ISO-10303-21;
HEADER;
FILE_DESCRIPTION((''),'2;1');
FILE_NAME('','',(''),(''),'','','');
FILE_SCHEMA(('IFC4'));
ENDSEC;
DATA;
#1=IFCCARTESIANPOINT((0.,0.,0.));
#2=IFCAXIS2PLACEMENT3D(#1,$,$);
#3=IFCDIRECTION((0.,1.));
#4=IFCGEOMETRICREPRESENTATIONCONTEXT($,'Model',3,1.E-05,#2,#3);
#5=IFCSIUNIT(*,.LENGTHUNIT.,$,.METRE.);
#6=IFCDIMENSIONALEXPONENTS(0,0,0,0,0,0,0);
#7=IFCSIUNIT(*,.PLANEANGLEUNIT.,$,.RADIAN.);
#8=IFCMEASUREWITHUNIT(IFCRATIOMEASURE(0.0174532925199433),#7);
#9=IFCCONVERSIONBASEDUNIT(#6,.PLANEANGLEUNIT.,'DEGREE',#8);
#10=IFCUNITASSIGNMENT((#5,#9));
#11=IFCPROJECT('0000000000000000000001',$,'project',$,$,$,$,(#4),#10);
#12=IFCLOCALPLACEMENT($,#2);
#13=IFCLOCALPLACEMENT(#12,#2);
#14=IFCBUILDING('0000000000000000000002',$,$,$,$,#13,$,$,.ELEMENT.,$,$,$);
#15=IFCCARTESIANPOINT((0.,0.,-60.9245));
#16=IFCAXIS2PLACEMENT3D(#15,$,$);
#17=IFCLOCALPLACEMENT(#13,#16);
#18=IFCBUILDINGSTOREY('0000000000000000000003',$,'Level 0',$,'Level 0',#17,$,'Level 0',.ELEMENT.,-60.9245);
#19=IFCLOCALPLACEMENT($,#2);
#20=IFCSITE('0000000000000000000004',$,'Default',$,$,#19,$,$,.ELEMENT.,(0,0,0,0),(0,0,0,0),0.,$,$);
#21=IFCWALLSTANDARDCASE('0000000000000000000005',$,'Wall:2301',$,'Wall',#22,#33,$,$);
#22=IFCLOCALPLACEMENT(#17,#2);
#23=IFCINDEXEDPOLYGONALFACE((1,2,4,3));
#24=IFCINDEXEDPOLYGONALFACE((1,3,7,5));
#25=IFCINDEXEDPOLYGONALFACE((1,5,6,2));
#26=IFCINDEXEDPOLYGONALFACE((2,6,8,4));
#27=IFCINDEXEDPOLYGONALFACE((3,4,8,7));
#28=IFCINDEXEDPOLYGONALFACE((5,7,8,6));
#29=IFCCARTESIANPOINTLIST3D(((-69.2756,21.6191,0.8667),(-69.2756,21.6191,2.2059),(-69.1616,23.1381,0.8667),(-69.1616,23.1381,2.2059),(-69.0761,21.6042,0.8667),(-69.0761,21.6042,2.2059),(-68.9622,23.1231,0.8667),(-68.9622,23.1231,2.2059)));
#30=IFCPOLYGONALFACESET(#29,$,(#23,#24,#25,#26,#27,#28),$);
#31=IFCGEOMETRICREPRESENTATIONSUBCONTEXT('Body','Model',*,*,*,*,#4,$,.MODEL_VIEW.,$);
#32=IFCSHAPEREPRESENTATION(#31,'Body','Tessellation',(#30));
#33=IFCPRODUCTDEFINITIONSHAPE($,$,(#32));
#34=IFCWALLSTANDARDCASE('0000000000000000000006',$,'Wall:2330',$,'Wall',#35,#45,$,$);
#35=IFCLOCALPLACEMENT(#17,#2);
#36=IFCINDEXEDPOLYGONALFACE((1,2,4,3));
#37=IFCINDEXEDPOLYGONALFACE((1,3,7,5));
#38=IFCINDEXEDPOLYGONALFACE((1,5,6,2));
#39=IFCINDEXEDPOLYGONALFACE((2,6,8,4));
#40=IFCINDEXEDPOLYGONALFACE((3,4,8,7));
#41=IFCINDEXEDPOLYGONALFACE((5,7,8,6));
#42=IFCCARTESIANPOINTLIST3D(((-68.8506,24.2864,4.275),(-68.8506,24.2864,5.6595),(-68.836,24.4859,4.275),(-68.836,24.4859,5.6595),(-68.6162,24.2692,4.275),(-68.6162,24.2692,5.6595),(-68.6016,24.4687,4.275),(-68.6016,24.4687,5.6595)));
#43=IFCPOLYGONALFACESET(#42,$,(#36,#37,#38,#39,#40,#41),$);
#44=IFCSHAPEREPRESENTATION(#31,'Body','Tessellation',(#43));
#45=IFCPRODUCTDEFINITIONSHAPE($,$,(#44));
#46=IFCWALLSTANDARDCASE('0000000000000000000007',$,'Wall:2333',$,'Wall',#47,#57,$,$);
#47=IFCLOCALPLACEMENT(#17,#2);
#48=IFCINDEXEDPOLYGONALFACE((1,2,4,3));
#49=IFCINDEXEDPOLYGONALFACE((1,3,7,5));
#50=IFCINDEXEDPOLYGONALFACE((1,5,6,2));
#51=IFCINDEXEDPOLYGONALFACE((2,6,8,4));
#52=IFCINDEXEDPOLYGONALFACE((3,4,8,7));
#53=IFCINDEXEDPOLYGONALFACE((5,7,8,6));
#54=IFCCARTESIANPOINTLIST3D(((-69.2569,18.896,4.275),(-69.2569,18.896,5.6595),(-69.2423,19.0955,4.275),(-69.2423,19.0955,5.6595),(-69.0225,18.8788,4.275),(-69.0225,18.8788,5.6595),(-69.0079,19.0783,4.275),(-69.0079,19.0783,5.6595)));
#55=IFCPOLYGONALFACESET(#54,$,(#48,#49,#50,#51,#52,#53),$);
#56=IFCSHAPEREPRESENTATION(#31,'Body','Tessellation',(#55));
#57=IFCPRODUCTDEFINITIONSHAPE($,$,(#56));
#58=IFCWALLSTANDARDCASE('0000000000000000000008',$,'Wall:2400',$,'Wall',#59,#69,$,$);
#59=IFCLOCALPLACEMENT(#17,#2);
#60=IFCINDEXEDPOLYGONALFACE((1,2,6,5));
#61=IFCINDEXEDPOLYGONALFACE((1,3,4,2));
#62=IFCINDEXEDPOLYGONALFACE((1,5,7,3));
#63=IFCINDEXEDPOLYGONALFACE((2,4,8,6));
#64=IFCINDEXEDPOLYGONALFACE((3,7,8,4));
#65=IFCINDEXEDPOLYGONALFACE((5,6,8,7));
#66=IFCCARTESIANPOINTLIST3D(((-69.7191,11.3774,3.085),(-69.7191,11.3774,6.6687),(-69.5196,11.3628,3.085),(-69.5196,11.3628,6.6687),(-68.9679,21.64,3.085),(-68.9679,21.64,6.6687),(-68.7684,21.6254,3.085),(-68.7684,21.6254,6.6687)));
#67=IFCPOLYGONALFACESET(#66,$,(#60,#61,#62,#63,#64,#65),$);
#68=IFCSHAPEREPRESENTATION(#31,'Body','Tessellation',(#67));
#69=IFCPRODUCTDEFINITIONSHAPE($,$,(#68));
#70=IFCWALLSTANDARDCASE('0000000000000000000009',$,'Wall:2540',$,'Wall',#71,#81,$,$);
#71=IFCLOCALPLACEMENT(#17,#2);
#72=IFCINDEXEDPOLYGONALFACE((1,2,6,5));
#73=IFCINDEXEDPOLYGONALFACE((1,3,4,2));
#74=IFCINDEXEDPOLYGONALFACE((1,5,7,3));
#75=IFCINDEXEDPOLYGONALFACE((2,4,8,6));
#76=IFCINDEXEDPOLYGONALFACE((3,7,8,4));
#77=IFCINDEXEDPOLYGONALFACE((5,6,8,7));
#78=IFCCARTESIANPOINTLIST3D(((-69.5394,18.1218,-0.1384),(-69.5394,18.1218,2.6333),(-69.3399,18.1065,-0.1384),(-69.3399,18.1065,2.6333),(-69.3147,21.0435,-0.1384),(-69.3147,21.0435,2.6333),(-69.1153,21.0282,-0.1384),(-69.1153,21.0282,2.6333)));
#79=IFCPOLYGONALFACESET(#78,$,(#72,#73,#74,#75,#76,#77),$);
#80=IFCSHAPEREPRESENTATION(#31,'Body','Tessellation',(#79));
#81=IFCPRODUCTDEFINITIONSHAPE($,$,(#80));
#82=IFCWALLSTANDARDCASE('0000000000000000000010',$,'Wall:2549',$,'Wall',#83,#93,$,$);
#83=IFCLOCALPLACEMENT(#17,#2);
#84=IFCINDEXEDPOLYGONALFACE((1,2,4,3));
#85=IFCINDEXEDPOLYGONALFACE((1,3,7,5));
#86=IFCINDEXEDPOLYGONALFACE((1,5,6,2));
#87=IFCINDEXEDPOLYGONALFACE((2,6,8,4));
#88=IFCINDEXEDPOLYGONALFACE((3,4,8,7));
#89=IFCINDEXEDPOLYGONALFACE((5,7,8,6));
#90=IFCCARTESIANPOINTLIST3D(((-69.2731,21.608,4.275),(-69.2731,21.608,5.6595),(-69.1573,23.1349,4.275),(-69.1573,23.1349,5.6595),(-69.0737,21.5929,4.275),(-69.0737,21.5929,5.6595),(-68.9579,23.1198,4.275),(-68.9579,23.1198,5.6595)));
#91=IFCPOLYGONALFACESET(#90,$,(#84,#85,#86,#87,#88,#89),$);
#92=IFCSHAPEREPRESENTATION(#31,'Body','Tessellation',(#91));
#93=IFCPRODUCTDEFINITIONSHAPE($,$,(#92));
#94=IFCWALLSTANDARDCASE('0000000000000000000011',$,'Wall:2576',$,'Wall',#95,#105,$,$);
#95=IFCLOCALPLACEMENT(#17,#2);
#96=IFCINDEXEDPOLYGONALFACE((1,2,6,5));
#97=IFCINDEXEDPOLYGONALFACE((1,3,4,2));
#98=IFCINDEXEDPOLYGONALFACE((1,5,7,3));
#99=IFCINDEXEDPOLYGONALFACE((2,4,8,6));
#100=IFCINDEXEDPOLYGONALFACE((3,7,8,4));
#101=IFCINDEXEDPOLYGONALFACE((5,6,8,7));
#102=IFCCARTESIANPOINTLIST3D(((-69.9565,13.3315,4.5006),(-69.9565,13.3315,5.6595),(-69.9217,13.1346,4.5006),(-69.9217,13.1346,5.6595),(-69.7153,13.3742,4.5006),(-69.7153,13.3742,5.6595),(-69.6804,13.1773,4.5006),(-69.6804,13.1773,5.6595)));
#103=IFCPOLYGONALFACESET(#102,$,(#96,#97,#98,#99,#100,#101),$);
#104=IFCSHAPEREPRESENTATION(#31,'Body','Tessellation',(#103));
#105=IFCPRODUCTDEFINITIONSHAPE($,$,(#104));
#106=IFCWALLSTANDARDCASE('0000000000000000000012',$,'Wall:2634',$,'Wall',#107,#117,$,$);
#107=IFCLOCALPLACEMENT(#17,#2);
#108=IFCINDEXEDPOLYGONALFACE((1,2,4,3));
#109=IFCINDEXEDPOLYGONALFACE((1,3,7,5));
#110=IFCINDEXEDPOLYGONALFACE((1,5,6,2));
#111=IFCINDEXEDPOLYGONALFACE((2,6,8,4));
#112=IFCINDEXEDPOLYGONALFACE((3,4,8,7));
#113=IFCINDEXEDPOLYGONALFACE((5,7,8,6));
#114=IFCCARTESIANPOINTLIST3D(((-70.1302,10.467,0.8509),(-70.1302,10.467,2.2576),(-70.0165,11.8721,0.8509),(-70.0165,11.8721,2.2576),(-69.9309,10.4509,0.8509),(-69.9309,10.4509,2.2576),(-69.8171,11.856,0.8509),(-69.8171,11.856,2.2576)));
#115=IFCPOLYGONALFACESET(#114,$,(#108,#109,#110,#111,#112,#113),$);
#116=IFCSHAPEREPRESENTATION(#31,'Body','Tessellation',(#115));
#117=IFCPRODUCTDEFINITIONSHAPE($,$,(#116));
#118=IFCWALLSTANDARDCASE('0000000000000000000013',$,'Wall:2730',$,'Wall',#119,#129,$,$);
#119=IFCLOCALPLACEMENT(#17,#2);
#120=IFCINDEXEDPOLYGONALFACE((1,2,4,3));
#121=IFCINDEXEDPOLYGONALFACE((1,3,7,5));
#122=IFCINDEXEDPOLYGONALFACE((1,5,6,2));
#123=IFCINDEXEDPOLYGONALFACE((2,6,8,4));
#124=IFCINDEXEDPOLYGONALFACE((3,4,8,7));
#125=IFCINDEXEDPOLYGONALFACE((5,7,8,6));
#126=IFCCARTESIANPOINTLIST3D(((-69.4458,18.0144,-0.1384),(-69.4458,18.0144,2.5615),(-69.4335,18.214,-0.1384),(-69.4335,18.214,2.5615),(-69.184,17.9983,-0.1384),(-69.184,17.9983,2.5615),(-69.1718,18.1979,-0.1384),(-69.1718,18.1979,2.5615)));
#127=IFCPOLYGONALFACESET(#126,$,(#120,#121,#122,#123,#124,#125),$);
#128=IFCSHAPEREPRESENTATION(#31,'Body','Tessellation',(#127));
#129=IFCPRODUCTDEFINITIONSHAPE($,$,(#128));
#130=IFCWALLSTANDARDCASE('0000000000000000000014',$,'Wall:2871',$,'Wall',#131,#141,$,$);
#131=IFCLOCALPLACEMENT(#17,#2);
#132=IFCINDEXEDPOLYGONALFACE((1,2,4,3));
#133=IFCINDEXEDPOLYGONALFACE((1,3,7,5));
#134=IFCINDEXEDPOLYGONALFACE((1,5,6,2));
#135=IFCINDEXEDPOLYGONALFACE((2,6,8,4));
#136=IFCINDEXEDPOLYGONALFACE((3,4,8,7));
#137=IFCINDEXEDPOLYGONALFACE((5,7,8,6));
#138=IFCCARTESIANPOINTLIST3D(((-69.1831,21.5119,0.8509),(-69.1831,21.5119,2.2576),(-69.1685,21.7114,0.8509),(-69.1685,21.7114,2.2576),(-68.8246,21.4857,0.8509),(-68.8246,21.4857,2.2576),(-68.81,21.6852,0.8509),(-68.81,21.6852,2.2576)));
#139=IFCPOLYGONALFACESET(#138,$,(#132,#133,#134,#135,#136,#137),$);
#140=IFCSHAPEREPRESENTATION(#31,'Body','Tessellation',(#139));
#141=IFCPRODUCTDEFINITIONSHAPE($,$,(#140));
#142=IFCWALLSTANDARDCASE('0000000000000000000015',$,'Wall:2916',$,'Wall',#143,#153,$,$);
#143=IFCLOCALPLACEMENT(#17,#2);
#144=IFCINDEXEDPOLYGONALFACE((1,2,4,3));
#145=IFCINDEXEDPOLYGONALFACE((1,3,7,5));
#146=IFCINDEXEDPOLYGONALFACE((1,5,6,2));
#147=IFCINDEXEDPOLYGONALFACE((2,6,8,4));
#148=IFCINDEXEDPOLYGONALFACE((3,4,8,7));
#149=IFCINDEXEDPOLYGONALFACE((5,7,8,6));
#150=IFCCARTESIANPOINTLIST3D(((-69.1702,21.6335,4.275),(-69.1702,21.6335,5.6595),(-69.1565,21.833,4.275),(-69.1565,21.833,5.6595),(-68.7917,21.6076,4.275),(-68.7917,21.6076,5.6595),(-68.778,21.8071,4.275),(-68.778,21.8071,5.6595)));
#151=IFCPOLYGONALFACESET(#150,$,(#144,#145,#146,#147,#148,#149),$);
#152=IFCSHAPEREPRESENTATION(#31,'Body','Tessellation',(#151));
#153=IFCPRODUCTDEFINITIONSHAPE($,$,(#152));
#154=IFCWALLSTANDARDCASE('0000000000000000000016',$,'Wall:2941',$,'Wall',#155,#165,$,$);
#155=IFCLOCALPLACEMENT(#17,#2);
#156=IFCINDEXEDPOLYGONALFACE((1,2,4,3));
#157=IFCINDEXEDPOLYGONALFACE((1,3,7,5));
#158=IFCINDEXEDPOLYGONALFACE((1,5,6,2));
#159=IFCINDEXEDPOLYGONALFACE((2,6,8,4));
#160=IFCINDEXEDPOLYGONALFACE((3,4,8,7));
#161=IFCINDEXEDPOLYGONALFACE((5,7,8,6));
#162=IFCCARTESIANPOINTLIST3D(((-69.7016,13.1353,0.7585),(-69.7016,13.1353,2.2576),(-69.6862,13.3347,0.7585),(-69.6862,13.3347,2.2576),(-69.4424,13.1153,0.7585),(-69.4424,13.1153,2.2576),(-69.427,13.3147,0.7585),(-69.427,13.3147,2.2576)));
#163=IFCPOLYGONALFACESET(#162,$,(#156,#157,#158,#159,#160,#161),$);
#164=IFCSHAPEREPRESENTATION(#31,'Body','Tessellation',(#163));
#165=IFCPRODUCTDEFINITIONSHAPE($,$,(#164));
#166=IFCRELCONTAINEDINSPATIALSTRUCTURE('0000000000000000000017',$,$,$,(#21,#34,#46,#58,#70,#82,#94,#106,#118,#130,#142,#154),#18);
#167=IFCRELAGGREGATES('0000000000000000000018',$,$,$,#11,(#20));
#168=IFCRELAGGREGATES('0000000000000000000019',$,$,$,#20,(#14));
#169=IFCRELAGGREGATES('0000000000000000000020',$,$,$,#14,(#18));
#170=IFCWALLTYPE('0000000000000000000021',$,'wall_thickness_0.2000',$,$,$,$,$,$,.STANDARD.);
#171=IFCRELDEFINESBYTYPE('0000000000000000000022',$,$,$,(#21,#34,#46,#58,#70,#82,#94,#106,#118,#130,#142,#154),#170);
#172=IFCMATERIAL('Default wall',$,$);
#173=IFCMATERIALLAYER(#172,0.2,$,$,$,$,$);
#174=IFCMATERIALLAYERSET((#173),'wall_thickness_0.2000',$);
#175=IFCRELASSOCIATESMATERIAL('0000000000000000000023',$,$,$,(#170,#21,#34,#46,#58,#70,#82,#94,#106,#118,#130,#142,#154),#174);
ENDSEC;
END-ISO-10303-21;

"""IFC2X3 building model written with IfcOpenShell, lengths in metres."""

from ifc_helpers import new_model, entity, si_unit, converted_unit, direction, frame, origin, place, context, subcontext, project, spatial, polyline, outline, extrude, material, layer, layer_set, layer_usage, type_object, element, save


model = new_model("IFC2X3")

# Units and contexts
model_context = context("Model", 3, precision=1e-05, world=origin(), true_north=direction((0.0, 1.0)))
body_context = subcontext(model_context, "Body", "Model", "MODEL_VIEW")
ifc_project = project(units=[si_unit("LENGTHUNIT", "METRE"), converted_unit("PLANEANGLEUNIT", "DEGREE", entity("IfcRatioMeasure", 0.0174532925199433), si_unit("PLANEANGLEUNIT", "RADIAN"), dimensions=[0, 0, 0, 0, 0, 0, 0])], contexts=[model_context])

# Site, building, storey
site_placement = place(None, origin())
site = spatial("IfcSite", under=ifc_project, at=site_placement, Name="Default", CompositionType="ELEMENT", RefLatitude=(0, 0, 0, 0), RefLongitude=(0, 0, 0, 0), RefElevation=0.0)
placement_1 = place(None, origin())
building_placement = place(placement_1, origin())
building = spatial("IfcBuilding", under=site, at=building_placement, CompositionType="ELEMENT")
storey_placement = place(building_placement, frame((0.0, 0.0, -60.9245)))
storey = spatial("IfcBuildingStorey", under=building, at=storey_placement, Name="Level 0", ObjectType="Level 0", LongName="Level 0", CompositionType="ELEMENT", Elevation=-60.9245)

# Walls
ifc_material = material(Name="Default wall")
ifc_layer = layer(ifc_material, 0.2)
ifc_layer_set = layer_set([ifc_layer], Name="wall_thickness_0.2000")
ifc_layer_usage = layer_usage(ifc_layer_set, "AXIS2", "POSITIVE", -0.1)
wall_type = type_object("IfcWallType", Name="wall_thickness_0.2000", PredefinedType="STANDARD", material=ifc_layer_set)
placement_2 = place(building_placement, frame((0.0, 0.0, -60.0578)))
wall_1_placement = place(placement_2, frame((-69.0619, 23.1306, 0.0), z_axis=(0.0, 0.0, 1.0), x_axis=(-0.074784, -0.9972, 0.0)))
element("IfcWallStandardCase", 1, at=wall_1_placement, inside=storey, type_object=wall_type, material=ifc_layer_usage, Name="Wall:2301", ObjectType="Wall", context=body_context, shape_type="SweptSolid", body=[
    extrude(outline(polyline([(1.5232, -0.1), (1.5232, 0.1), (0.0, 0.1), (0.0, -0.1), (1.5232, -0.1)])), origin(), (0.0, 0.0, 1.0), 1.3392),
])
placement_3 = place(building_placement, frame((0.0, 0.0, -56.6495)))
wall_2_placement = place(placement_3, frame((-68.6089, 24.369, 0.0), z_axis=(0.0, 0.0, 1.0), x_axis=(-0.997327, 0.073063, 0.0)))
element("IfcWallStandardCase", 2, at=wall_2_placement, inside=storey, type_object=wall_type, material=ifc_layer_usage, Name="Wall:2330", ObjectType="Wall", context=body_context, shape_type="SweptSolid", body=[
    extrude(outline(polyline([(0.235, -0.1), (0.235, 0.1), (0.0, 0.1), (0.0, -0.1), (0.235, -0.1)])), origin(), (0.0, 0.0, 1.0), 1.3845),
])
placement_4 = place(building_placement, frame((0.0, 0.0, -56.6495)))
wall_3_placement = place(placement_4, frame((-69.0152, 18.9786, 0.0), z_axis=(0.0, 0.0, 1.0), x_axis=(-0.997326, 0.073081, 0.0)))
element("IfcWallStandardCase", 3, at=wall_3_placement, inside=storey, type_object=wall_type, material=ifc_layer_usage, Name="Wall:2333", ObjectType="Wall", context=body_context, shape_type="SweptSolid", body=[
    extrude(outline(polyline([(0.235, -0.1), (0.235, 0.1), (0.0, 0.1), (0.0, -0.1), (0.235, -0.1)])), origin(), (0.0, 0.0, 1.0), 1.3845),
])
placement_5 = place(building_placement, frame((0.0, 0.0, -57.8395)))
wall_4_placement = place(placement_5, frame((-68.8681, 21.6327, 0.0), z_axis=(0.0, 0.0, 1.0), x_axis=(-0.073003, -0.997332, 0.0)))
element("IfcWallStandardCase", 4, at=wall_4_placement, inside=storey, type_object=wall_type, material=ifc_layer_usage, Name="Wall:2400", ObjectType="Wall", context=body_context, shape_type="SweptSolid", body=[
    extrude(outline(polyline([(10.29, -0.1), (10.29, 0.1), (0.0, 0.1), (0.0, -0.1), (10.29, -0.1)])), origin(), (0.0, 0.0, 1.0), 3.5837),
])
placement_6 = place(building_placement, frame((0.0, 0.0, -61.0629)))
wall_5_placement = place(placement_6, frame((-69.215, 21.0358, 0.0), z_axis=(0.0, 0.0, 1.0), x_axis=(-0.076651, -0.997058, 0.0)))
element("IfcWallStandardCase", 5, at=wall_5_placement, inside=storey, type_object=wall_type, material=ifc_layer_usage, Name="Wall:2540", ObjectType="Wall", context=body_context, shape_type="SweptSolid", body=[
    extrude(outline(polyline([(2.9303, -0.1), (2.9303, 0.1), (0.0, 0.1), (0.0, -0.1), (2.9303, -0.1)])), origin(), (0.0, 0.0, 1.0), 2.7716),
])
placement_7 = place(building_placement, frame((0.0, 0.0, -56.6495)))
wall_6_placement = place(placement_7, frame((-69.0576, 23.1274, 0.0), z_axis=(0.0, 0.0, 1.0), x_axis=(-0.075624, -0.997136, 0.0)))
element("IfcWallStandardCase", 6, at=wall_6_placement, inside=storey, type_object=wall_type, material=ifc_layer_usage, Name="Wall:2549", ObjectType="Wall", context=body_context, shape_type="SweptSolid", body=[
    extrude(outline(polyline([(1.5313, -0.1), (1.5313, 0.1), (0.0, 0.1), (0.0, -0.1), (1.5313, -0.1)])), origin(), (0.0, 0.0, 1.0), 1.3845),
])
placement_8 = place(building_placement, frame((0.0, 0.0, -56.4239)))
wall_7_placement = place(placement_8, frame((-69.6979, 13.2758, 0.0), z_axis=(0.0, 0.0, 1.0), x_axis=(-0.984687, -0.174331, 0.0)))
element("IfcWallStandardCase", 7, at=wall_7_placement, inside=storey, type_object=wall_type, material=ifc_layer_usage, Name="Wall:2576", ObjectType="Wall", context=body_context, shape_type="SweptSolid", body=[
    extrude(outline(polyline([(0.245, -0.1), (0.245, 0.1), (0.0, 0.1), (0.0, -0.1), (0.245, -0.1)])), origin(), (0.0, 0.0, 1.0), 1.1589),
])
placement_9 = place(building_placement, frame((0.0, 0.0, -60.0736)))
wall_8_placement = place(placement_9, frame((-69.9168, 11.864, 0.0), z_axis=(0.0, 0.0, 1.0), x_axis=(-0.080694, -0.996739, 0.0)))
element("IfcWallStandardCase", 8, at=wall_8_placement, inside=storey, type_object=wall_type, material=ifc_layer_usage, Name="Wall:2634", ObjectType="Wall", context=body_context, shape_type="SweptSolid", body=[
    extrude(outline(polyline([(1.4097, -0.1), (1.4097, 0.1), (0.0, 0.1), (0.0, -0.1), (1.4097, -0.1)])), origin(), (0.0, 0.0, 1.0), 1.4068),
])
placement_10 = place(building_placement, frame((0.0, 0.0, -61.0629)))
wall_9_placement = place(placement_10, frame((-69.1779, 18.0981, 0.0), z_axis=(0.0, 0.0, 1.0), x_axis=(-0.998125, 0.061214, 0.0)))
element("IfcWallStandardCase", 9, at=wall_9_placement, inside=storey, type_object=wall_type, material=ifc_layer_usage, Name="Wall:2730", ObjectType="Wall", context=body_context, shape_type="SweptSolid", body=[
    extrude(outline(polyline([(0.2623, -0.1), (0.2623, 0.1), (0.0, 0.1), (0.0, -0.1), (0.2623, -0.1)])), origin(), (0.0, 0.0, 1.0), 2.6999),
])
placement_11 = place(building_placement, frame((0.0, 0.0, -60.0736)))
wall_10_placement = place(placement_11, frame((-68.8173, 21.5854, 0.0), z_axis=(0.0, 0.0, 1.0), x_axis=(-0.997342, 0.072862, 0.0)))
element("IfcWallStandardCase", 10, at=wall_10_placement, inside=storey, type_object=wall_type, material=ifc_layer_usage, Name="Wall:2871", ObjectType="Wall", context=body_context, shape_type="SweptSolid", body=[
    extrude(outline(polyline([(0.3595, -0.1), (0.3595, 0.1), (0.0, 0.1), (0.0, -0.1), (0.3595, -0.1)])), origin(), (0.0, 0.0, 1.0), 1.4068),
])
placement_12 = place(building_placement, frame((0.0, 0.0, -56.6495)))
wall_11_placement = place(placement_12, frame((-68.7849, 21.7073, 0.0), z_axis=(0.0, 0.0, 1.0), x_axis=(-0.997661, 0.068361, 0.0)))
element("IfcWallStandardCase", 11, at=wall_11_placement, inside=storey, type_object=wall_type, material=ifc_layer_usage, Name="Wall:2916", ObjectType="Wall", context=body_context, shape_type="SweptSolid", body=[
    extrude(outline(polyline([(0.3793, -0.1), (0.3793, 0.1), (0.0, 0.1), (0.0, -0.1), (0.3793, -0.1)])), origin(), (0.0, 0.0, 1.0), 1.3845),
])
placement_13 = place(building_placement, frame((0.0, 0.0, -60.166)))
wall_12_placement = place(placement_13, frame((-69.4347, 13.215, 0.0), z_axis=(0.0, 0.0, 1.0), x_axis=(-0.997026, 0.077069, 0.0)))
element("IfcWallStandardCase", 12, at=wall_12_placement, inside=storey, type_object=wall_type, material=ifc_layer_usage, Name="Wall:2941", ObjectType="Wall", context=body_context, shape_type="SweptSolid", body=[
    extrude(outline(polyline([(0.26, -0.1), (0.26, 0.1), (0.0, 0.1), (0.0, -0.1), (0.26, -0.1)])), origin(), (0.0, 0.0, 1.0), 1.4991),
])

save(model, "model.ifc")
